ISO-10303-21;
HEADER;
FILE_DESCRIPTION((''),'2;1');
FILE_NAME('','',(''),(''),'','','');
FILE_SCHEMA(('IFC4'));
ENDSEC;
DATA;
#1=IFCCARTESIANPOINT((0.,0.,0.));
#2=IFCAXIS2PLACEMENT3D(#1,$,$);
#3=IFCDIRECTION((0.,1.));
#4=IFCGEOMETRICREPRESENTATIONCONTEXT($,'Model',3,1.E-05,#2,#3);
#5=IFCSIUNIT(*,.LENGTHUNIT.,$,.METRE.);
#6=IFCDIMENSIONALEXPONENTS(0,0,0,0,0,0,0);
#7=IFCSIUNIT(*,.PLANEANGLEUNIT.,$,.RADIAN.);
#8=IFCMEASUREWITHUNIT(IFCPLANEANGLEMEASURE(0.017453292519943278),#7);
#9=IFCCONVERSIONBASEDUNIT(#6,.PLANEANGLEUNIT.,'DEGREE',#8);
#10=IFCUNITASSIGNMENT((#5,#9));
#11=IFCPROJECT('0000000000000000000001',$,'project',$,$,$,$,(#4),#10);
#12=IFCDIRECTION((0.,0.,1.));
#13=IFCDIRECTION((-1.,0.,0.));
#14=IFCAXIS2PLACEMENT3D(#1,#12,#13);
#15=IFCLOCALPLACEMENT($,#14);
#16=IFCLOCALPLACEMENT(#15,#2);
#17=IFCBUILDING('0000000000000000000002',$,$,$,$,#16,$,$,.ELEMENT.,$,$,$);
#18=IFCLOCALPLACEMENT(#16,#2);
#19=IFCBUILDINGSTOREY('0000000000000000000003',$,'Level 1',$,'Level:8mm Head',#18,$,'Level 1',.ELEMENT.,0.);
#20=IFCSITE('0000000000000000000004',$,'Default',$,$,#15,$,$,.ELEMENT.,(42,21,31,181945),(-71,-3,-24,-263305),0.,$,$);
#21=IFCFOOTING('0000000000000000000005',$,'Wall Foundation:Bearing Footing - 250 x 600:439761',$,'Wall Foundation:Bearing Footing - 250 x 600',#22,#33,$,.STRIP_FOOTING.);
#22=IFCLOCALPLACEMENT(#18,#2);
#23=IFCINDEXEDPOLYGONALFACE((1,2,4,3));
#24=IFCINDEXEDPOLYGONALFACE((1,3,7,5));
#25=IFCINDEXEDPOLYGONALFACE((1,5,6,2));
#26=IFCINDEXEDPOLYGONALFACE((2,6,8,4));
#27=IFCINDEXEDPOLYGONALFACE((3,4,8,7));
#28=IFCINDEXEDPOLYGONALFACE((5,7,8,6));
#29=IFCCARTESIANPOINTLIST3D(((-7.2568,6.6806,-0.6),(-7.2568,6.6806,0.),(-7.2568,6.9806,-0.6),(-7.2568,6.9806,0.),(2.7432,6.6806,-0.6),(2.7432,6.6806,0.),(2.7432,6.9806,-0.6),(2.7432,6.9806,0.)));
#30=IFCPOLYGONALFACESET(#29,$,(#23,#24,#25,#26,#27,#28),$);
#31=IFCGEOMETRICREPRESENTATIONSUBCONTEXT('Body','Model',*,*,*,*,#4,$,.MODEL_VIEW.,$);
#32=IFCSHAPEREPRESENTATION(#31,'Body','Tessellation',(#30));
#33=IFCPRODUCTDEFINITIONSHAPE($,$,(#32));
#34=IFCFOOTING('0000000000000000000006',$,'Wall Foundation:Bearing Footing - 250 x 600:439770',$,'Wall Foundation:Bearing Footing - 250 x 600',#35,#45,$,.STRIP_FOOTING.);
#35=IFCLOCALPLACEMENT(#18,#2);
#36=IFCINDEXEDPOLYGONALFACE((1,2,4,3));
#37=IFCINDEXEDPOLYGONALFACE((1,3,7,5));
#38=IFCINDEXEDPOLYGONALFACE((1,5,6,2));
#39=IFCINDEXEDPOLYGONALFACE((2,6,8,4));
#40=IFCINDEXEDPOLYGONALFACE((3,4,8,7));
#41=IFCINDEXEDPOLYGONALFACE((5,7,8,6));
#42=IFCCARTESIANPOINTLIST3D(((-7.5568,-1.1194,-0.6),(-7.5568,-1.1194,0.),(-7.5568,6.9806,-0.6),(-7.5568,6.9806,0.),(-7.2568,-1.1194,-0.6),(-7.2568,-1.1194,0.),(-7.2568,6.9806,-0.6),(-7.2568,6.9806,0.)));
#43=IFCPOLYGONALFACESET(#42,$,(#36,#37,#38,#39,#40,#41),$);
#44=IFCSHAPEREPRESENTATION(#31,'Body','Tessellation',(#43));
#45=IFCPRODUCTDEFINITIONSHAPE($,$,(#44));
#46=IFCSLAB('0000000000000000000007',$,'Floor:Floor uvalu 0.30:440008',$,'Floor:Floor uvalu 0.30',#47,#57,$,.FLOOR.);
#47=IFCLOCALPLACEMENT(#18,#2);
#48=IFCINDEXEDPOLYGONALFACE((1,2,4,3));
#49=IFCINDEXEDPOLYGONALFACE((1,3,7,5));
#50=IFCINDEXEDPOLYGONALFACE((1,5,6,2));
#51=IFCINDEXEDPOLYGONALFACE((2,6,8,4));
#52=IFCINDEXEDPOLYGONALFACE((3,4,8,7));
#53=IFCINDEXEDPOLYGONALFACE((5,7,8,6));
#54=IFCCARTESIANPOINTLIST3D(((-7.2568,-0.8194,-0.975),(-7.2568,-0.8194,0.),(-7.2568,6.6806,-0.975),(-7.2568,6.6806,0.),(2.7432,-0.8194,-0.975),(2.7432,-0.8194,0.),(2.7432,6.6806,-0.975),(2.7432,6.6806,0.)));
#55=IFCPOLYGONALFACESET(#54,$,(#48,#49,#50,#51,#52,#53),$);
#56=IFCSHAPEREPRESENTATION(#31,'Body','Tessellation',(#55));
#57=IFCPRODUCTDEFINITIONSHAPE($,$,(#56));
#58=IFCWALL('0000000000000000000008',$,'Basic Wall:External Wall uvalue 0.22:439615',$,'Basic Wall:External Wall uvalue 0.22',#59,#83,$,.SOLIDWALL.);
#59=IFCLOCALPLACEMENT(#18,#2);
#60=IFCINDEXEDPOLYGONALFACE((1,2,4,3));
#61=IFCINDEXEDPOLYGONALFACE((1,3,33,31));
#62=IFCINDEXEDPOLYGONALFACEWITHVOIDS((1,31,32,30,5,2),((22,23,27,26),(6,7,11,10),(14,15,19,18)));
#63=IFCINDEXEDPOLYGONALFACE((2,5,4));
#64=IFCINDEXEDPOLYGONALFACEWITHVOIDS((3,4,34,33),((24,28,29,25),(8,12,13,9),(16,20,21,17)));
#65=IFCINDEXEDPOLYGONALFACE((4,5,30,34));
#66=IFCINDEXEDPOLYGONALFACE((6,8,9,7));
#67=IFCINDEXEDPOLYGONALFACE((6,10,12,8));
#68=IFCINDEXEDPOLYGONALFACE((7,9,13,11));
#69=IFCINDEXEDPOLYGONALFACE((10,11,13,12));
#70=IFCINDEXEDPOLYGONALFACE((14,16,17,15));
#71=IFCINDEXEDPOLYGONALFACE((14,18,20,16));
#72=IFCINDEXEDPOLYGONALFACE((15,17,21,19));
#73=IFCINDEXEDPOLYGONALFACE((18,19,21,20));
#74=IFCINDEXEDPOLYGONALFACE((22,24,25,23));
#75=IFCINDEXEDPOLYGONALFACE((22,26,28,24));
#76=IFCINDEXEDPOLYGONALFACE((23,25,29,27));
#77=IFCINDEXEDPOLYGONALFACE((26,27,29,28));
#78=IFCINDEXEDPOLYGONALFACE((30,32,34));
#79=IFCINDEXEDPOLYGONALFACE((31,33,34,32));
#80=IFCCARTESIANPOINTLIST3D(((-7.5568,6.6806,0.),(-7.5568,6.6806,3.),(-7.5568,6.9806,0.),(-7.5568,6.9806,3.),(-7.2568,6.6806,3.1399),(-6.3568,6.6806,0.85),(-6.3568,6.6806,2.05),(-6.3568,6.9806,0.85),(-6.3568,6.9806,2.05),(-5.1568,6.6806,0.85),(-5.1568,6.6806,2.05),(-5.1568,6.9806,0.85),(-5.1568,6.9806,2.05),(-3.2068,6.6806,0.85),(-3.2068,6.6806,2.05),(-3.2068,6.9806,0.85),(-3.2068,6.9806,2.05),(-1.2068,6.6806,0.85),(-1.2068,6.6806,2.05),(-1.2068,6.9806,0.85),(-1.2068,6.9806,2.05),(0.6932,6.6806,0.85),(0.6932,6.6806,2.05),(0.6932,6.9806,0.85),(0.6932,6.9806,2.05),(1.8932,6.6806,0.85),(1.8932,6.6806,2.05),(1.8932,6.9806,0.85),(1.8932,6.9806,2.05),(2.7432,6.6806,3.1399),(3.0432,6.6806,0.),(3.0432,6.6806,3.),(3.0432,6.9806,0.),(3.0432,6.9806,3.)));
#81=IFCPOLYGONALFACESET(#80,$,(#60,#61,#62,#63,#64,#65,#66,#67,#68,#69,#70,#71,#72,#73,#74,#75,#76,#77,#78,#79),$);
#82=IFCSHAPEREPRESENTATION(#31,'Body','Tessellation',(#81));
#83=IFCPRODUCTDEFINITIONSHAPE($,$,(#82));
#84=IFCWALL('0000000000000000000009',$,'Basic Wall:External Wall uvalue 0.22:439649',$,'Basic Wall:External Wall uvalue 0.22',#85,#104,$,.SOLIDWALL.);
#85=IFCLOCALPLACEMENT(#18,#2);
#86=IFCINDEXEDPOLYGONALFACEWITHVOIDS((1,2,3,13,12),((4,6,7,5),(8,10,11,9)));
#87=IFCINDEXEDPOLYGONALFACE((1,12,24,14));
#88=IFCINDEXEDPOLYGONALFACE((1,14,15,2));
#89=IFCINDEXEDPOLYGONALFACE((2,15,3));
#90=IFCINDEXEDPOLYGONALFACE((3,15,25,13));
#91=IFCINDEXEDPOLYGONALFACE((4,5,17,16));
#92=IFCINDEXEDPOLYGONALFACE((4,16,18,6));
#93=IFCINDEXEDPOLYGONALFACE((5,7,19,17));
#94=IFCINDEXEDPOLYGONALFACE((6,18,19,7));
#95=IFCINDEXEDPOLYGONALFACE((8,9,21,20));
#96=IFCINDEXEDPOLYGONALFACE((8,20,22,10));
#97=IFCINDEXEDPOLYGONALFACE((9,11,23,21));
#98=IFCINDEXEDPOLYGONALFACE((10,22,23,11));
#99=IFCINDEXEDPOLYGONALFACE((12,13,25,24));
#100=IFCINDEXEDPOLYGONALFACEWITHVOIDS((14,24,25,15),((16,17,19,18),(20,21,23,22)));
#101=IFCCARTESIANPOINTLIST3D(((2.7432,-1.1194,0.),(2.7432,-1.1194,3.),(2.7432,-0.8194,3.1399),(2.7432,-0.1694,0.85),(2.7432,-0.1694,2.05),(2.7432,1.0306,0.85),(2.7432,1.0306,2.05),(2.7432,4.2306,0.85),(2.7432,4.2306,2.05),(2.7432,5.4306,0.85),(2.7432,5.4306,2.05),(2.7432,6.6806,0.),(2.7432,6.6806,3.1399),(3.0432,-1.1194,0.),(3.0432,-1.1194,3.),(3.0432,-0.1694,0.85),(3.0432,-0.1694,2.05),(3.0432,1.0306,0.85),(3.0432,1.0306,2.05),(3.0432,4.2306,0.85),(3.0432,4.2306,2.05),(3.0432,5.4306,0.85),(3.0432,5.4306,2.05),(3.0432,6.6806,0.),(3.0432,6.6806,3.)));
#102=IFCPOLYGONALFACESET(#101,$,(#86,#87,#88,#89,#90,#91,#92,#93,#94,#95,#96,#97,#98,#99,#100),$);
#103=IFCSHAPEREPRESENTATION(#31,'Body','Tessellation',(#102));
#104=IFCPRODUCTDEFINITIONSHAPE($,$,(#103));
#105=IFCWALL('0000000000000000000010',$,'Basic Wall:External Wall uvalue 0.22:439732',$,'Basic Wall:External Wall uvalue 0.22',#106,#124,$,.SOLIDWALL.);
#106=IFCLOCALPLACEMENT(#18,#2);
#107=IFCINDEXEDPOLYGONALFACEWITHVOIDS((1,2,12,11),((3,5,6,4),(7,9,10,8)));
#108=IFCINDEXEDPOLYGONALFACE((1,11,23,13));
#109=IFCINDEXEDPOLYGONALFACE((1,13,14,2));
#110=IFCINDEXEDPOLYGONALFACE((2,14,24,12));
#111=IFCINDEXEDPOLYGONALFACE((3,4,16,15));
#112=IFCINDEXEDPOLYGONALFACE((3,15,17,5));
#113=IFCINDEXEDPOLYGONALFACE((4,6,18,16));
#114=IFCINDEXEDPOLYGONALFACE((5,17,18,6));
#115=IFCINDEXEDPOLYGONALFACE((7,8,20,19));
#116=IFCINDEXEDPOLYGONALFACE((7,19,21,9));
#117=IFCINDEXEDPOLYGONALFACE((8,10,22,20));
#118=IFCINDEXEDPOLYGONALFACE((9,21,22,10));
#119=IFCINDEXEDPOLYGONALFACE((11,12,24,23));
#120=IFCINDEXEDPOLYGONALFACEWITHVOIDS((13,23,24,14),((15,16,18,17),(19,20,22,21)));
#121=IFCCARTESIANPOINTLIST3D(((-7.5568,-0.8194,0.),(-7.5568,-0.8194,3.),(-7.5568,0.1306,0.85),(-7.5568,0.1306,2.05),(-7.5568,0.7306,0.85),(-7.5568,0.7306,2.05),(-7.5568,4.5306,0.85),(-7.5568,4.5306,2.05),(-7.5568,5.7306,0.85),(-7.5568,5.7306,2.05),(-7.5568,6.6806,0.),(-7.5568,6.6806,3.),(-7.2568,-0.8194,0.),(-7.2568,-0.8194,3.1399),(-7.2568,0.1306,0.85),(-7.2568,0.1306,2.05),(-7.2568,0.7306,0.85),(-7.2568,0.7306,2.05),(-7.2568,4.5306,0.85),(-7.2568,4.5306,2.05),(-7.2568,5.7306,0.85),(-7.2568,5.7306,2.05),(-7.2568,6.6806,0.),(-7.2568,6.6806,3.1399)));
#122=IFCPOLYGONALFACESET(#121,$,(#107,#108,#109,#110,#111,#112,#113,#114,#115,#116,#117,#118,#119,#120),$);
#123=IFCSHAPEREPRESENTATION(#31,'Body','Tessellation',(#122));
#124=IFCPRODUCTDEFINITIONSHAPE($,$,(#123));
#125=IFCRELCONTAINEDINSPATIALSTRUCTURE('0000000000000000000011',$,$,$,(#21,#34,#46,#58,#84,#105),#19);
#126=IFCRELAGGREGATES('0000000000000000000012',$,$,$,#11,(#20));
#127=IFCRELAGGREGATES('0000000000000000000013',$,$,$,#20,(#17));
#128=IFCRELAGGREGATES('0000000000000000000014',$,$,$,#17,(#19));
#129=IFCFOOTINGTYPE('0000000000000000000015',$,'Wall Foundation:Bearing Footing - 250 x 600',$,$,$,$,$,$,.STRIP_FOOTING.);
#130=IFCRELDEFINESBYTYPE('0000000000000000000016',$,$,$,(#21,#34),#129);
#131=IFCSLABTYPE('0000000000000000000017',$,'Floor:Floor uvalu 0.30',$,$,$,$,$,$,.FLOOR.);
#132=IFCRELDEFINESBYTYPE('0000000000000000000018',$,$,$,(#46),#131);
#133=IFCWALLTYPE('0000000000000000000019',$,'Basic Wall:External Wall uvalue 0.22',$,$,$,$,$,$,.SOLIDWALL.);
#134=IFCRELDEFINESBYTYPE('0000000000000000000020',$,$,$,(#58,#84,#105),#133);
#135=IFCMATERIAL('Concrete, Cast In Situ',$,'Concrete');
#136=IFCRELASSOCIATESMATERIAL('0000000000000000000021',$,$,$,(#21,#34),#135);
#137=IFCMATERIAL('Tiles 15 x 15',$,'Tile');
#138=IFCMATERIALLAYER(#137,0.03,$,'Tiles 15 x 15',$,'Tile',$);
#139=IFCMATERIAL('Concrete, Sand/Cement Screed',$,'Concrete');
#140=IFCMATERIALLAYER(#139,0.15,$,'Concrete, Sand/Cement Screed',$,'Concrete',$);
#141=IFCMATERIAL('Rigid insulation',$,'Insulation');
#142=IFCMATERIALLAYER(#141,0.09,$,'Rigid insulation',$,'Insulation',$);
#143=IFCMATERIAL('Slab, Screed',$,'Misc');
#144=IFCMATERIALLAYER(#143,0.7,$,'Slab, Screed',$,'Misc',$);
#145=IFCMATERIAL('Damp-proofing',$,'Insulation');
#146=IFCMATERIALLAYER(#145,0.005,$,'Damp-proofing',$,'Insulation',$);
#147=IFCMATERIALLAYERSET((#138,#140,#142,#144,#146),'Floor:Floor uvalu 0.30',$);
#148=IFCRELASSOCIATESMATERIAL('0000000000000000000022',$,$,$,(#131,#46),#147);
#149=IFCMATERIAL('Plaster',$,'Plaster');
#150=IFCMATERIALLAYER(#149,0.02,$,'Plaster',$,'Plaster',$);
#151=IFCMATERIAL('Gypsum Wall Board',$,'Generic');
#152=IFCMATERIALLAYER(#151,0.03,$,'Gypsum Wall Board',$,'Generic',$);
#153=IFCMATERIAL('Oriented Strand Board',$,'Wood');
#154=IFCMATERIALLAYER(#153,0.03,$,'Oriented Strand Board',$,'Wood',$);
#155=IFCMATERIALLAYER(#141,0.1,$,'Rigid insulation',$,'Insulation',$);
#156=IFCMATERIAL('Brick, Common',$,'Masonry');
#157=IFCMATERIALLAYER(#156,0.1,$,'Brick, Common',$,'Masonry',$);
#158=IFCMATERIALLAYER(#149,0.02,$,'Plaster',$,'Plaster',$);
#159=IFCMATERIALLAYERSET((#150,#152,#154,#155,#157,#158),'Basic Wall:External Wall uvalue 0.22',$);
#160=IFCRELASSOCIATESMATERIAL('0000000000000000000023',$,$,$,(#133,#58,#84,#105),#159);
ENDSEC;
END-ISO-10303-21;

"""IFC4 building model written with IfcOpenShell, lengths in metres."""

from ifc_helpers import new_model, entity, si_unit, converted_unit, direction, frame, frame_2d, origin, origin_2d_with_axis, place, context, subcontext, project, spatial, polyline, rectangle, extrude, clip, bounded_halfspace, material, layer, layer_set, layer_usage, type_object, element, save


model = new_model("IFC4")

# Units and contexts
model_context = context("Model", 3, precision=1e-05, world=origin(), true_north=direction((0.0, 1.0)))
body_context = subcontext(model_context, "Body", "Model", "MODEL_VIEW")
ifc_project = project(units=[si_unit("LENGTHUNIT", "METRE"), converted_unit("PLANEANGLEUNIT", "DEGREE", entity("IfcPlaneAngleMeasure", 0.017453292519943278), si_unit("PLANEANGLEUNIT", "RADIAN"), dimensions=[0, 0, 0, 0, 0, 0, 0])], contexts=[model_context])

# Site, building, storey
site_placement = place(None, frame((0.0, 0.0, 0.0), z_axis=(0.0, 0.0, 1.0), x_axis=(-1.0, 0.0, 0.0)))
site = spatial("IfcSite", under=ifc_project, at=site_placement, Name="Default", CompositionType="ELEMENT", RefLatitude=(42, 21, 31, 181945), RefLongitude=(-71, -3, -24, -263305), RefElevation=0.0)
building_placement = place(site_placement, origin())
building = spatial("IfcBuilding", under=site, at=building_placement, CompositionType="ELEMENT")
storey_placement = place(building_placement, origin())
storey = spatial("IfcBuildingStorey", under=building, at=storey_placement, Name="Level 1", ObjectType="Level:8mm Head", LongName="Level 1", CompositionType="ELEMENT", Elevation=0.0)

# Footings
ifc_material_1 = material(Name="Concrete, Cast In Situ", Category="Concrete")
footing_type = type_object("IfcFootingType", Name="Wall Foundation:Bearing Footing - 250 x 600", PredefinedType="STRIP_FOOTING")
footing_1_placement = place(storey_placement, frame((-7.2568, 6.6806, -0.6)))
element("IfcFooting", 1, at=footing_1_placement, inside=storey, type_object=footing_type, material=ifc_material_1, Name="Wall Foundation:Bearing Footing - 250 x 600:439761", ObjectType="Wall Foundation:Bearing Footing - 250 x 600", PredefinedType="STRIP_FOOTING", context=body_context, shape_type="SweptSolid", body=[
    extrude(rectangle(XDim=10.0, YDim=0.3, at=frame_2d((0.0, 0.0), x_axis=(1.0, 0.0))), frame((5.0, 0.15, 0.0)), (0.0, 0.0, 1.0), 0.6),
])
footing_2_placement = place(storey_placement, frame((-7.5568, -1.1194, -0.6)))
element("IfcFooting", 2, at=footing_2_placement, inside=storey, type_object=footing_type, material=ifc_material_1, Name="Wall Foundation:Bearing Footing - 250 x 600:439770", ObjectType="Wall Foundation:Bearing Footing - 250 x 600", PredefinedType="STRIP_FOOTING", context=body_context, shape_type="SweptSolid", body=[
    extrude(rectangle(XDim=8.1, YDim=0.3, at=frame_2d((0.0, 0.05), x_axis=(1.0, 0.0))), frame((0.2, 4.05, 0.0), z_axis=(0.0, 0.0, 1.0), x_axis=(0.0, 1.0, 0.0)), (0.0, 0.0, 1.0), 0.6),
])

# Slab
ifc_material_2 = material(Name="Tiles 15 x 15", Category="Tile")
ifc_layer_1 = layer(ifc_material_2, 0.03, Name="Tiles 15 x 15", Category="Tile")
ifc_material_3 = material(Name="Concrete, Sand/Cement Screed", Category="Concrete")
ifc_layer_2 = layer(ifc_material_3, 0.15, Name="Concrete, Sand/Cement Screed", Category="Concrete")
ifc_material_4 = material(Name="Rigid insulation", Category="Insulation")
ifc_layer_3 = layer(ifc_material_4, 0.09, Name="Rigid insulation", Category="Insulation")
ifc_material_5 = material(Name="Slab, Screed", Category="Misc")
ifc_layer_4 = layer(ifc_material_5, 0.7, Name="Slab, Screed", Category="Misc")
ifc_material_6 = material(Name="Damp-proofing", Category="Insulation")
ifc_layer_5 = layer(ifc_material_6, 0.005, Name="Damp-proofing", Category="Insulation")
ifc_layer_set_1 = layer_set([ifc_layer_1, ifc_layer_2, ifc_layer_3, ifc_layer_4, ifc_layer_5], Name="Floor:Floor uvalu 0.30")
ifc_layer_usage_1 = layer_usage(ifc_layer_set_1, "AXIS3", "POSITIVE", 0.0)
slab_type = type_object("IfcSlabType", Name="Floor:Floor uvalu 0.30", PredefinedType="FLOOR", material=ifc_layer_set_1)
slab_placement = place(storey_placement, origin())
element("IfcSlab", 3, at=slab_placement, inside=storey, type_object=slab_type, material=ifc_layer_usage_1, Name="Floor:Floor uvalu 0.30:440008", ObjectType="Floor:Floor uvalu 0.30", PredefinedType="FLOOR", context=body_context, shape_type="SweptSolid", body=[
    extrude(rectangle(XDim=7.5, YDim=10.0, at=origin_2d_with_axis()), frame((-2.2568, 2.9306, 0.0), z_axis=(0.0, 0.0, -1.0), x_axis=(0.0, 1.0, 0.0)), (0.0, 0.0, 1.0), 0.975),
])

# Walls, openings
ifc_material_7 = material(Name="Plaster", Category="Plaster")
ifc_layer_6 = layer(ifc_material_7, 0.02, Name="Plaster", Category="Plaster")
ifc_material_8 = material(Name="Gypsum Wall Board", Category="Generic")
ifc_layer_7 = layer(ifc_material_8, 0.03, Name="Gypsum Wall Board", Category="Generic")
ifc_material_9 = material(Name="Oriented Strand Board", Category="Wood")
ifc_layer_8 = layer(ifc_material_9, 0.03, Name="Oriented Strand Board", Category="Wood")
ifc_layer_9 = layer(ifc_material_4, 0.1, Name="Rigid insulation", Category="Insulation")
ifc_material_10 = material(Name="Brick, Common", Category="Masonry")
ifc_layer_10 = layer(ifc_material_10, 0.1, Name="Brick, Common", Category="Masonry")
ifc_layer_11 = layer(ifc_material_7, 0.02, Name="Plaster", Category="Plaster")
ifc_layer_set_2 = layer_set([ifc_layer_6, ifc_layer_7, ifc_layer_8, ifc_layer_9, ifc_layer_10, ifc_layer_11], Name="Basic Wall:External Wall uvalue 0.22")
ifc_layer_usage_2 = layer_usage(ifc_layer_set_2, "AXIS2", "NEGATIVE", 0.15)
wall_type_1 = type_object("IfcWallType", Name="Basic Wall:External Wall uvalue 0.22", PredefinedType="SOLIDWALL", material=ifc_layer_set_2)
wall_1_placement = place(storey_placement, frame((-7.5568, 6.8306, 0.0)))
wall_1 = element("IfcWall", 4, at=wall_1_placement, inside=storey, type_object=wall_type_1, material=ifc_layer_usage_2, Name="Basic Wall:External Wall uvalue 0.22:439615", ObjectType="Basic Wall:External Wall uvalue 0.22", PredefinedType="SOLIDWALL", context=body_context, shape_type="Clipping", body=[
    clip(clip(clip(extrude(rectangle(XDim=10.6, YDim=0.3, at=frame_2d((5.3, 0.0), x_axis=(-1.0, 0.0))), origin(), (0.0, 0.0, 1.0), 3.1399), bounded_halfspace(frame((0.3, -0.15, 3.1399), z_axis=(0.0, 0.422618, 0.906308), x_axis=(-1.0, 0.0, 0.0)), False, frame((0.3, -0.15, 3.1399)), polyline([(0.0, 0.0), (10.0, 0.0), (10.3, 0.3), (-0.3, 0.3), (0.0, 0.0)]))), bounded_halfspace(frame((0.0, -0.15, 3.0), z_axis=(-0.422618, 0.0, 0.906308), x_axis=(0.0, -1.0, 0.0)), False, frame((0.0, -0.15, 3.0)), polyline([(0.0, 0.0), (0.3, 0.0), (0.0, 0.3), (0.0, 0.0)]))), bounded_halfspace(frame((10.3, -0.15, 3.1399), z_axis=(0.422618, 0.0, 0.906308), x_axis=(0.0, 1.0, 0.0)), False, frame((10.3, -0.15, 3.1399)), polyline([(0.0, 0.0), (0.3, 0.0), (0.3, 0.3), (0.0, 0.0)]))),
])
opening_1_placement = place(wall_1_placement, frame((1.2, -0.15, 0.85)))
element("IfcOpeningElement", 5, at=opening_1_placement, cuts=wall_1, PredefinedType="OPENING", context=body_context, shape_type="SweptSolid", body=[
    extrude(rectangle(XDim=1.2, YDim=1.2, at=frame_2d((0.6, 0.6), x_axis=(1.0, 0.0))), frame((0.0, 0.0, 0.0), z_axis=(0.0, 1.0, 0.0), x_axis=(0.0, 0.0, 1.0)), (0.0, 0.0, 1.0), 0.3),
])
opening_2_placement = place(wall_1_placement, frame((8.25, -0.15, 0.85)))
element("IfcOpeningElement", 6, at=opening_2_placement, cuts=wall_1, PredefinedType="OPENING", context=body_context, shape_type="SweptSolid", body=[
    extrude(rectangle(XDim=1.2, YDim=1.2, at=frame_2d((0.6, 0.6), x_axis=(1.0, 0.0))), frame((0.0, 0.0, 0.0), z_axis=(0.0, 1.0, 0.0), x_axis=(0.0, 0.0, 1.0)), (0.0, 0.0, 1.0), 0.3),
])
opening_3_placement = place(wall_1_placement, frame((4.35, -0.15, 0.85)))
element("IfcOpeningElement", 7, at=opening_3_placement, cuts=wall_1, PredefinedType="OPENING", context=body_context, shape_type="SweptSolid", body=[
    extrude(rectangle(XDim=1.2, YDim=2.0, at=frame_2d((0.6, 1.0), x_axis=(1.0, 0.0))), frame((0.0, 0.0, 0.0), z_axis=(0.0, 1.0, 0.0), x_axis=(0.0, 0.0, 1.0)), (0.0, 0.0, 1.0), 0.3),
])
wall_2_placement = place(storey_placement, frame((2.8932, 6.6806, 0.0), z_axis=(0.0, 0.0, 1.0), x_axis=(0.0, -1.0, 0.0)))
wall_2 = element("IfcWall", 8, at=wall_2_placement, inside=storey, type_object=wall_type_1, material=ifc_layer_usage_2, Name="Basic Wall:External Wall uvalue 0.22:439649", ObjectType="Basic Wall:External Wall uvalue 0.22", PredefinedType="SOLIDWALL", context=body_context, shape_type="Clipping", body=[
    clip(clip(extrude(rectangle(XDim=7.8, YDim=0.3, at=frame_2d((3.9, 0.0), x_axis=(-1.0, 0.0))), origin(), (0.0, 0.0, 1.0), 3.1399), bounded_halfspace(frame((7.5, -0.15, 3.1399), z_axis=(0.422618, 0.0, 0.906308), x_axis=(0.0, 1.0, 0.0)), False, frame((7.5, -0.15, 3.1399)), polyline([(0.0, 0.0), (0.3, 0.0), (0.3, 0.3), (0.0, 0.0)]))), bounded_halfspace(frame((0.0, -0.15, 3.1399), z_axis=(0.0, 0.422618, 0.906308), x_axis=(-1.0, 0.0, 0.0)), False, frame((0.0, -0.15, 3.1399)), polyline([(0.0, 0.0), (7.5, 0.0), (7.8, 0.3), (0.0, 0.3), (0.0, 0.0)]))),
])
opening_4_placement = place(wall_2_placement, frame((1.25, -0.15, 0.85)))
element("IfcOpeningElement", 9, at=opening_4_placement, cuts=wall_2, PredefinedType="OPENING", context=body_context, shape_type="SweptSolid", body=[
    extrude(rectangle(XDim=1.2, YDim=1.2, at=frame_2d((0.6, 0.6), x_axis=(1.0, 0.0))), frame((0.0, 0.0, 0.0), z_axis=(0.0, 1.0, 0.0), x_axis=(0.0, 0.0, 1.0)), (0.0, 0.0, 1.0), 0.3),
])
opening_5_placement = place(wall_2_placement, frame((6.85, 0.15, 0.85)))
element("IfcOpeningElement", 10, at=opening_5_placement, cuts=wall_2, PredefinedType="OPENING", context=body_context, shape_type="SweptSolid", body=[
    extrude(rectangle(XDim=1.2, YDim=1.2, at=frame_2d((0.6, 0.6), x_axis=(1.0, 0.0))), frame((0.0, 0.0, 0.0), z_axis=(0.0, -1.0, 0.0), x_axis=(0.0, 0.0, 1.0)), (0.0, 0.0, 1.0), 0.3),
])
wall_3_placement = place(storey_placement, frame((-7.4068, -0.8194, 0.0), z_axis=(0.0, 0.0, 1.0), x_axis=(0.0, 1.0, 0.0)))
wall_3 = element("IfcWall", 11, at=wall_3_placement, inside=storey, type_object=wall_type_1, material=ifc_layer_usage_2, Name="Basic Wall:External Wall uvalue 0.22:439732", ObjectType="Basic Wall:External Wall uvalue 0.22", PredefinedType="SOLIDWALL", context=body_context, shape_type="Clipping", body=[
    clip(extrude(rectangle(XDim=7.5, YDim=0.3, at=frame_2d((3.75, 0.0), x_axis=(-1.0, 0.0))), origin(), (0.0, 0.0, 1.0), 3.1399), bounded_halfspace(frame((0.0, -0.15, 3.1399), z_axis=(0.0, 0.422618, 0.906308), x_axis=(-1.0, 0.0, 0.0)), False, frame((0.0, -0.15, 3.1399)), polyline([(0.0, 0.0), (7.5, 0.0), (7.5, 0.3), (0.0, 0.3), (0.0, 0.0)]))),
])
opening_6_placement = place(wall_3_placement, frame((5.35, -0.15, 0.85)))
element("IfcOpeningElement", 12, at=opening_6_placement, cuts=wall_3, PredefinedType="OPENING", context=body_context, shape_type="SweptSolid", body=[
    extrude(rectangle(XDim=1.2, YDim=1.2, at=frame_2d((0.6, 0.6), x_axis=(1.0, 0.0))), frame((0.0, 0.0, 0.0), z_axis=(0.0, 1.0, 0.0), x_axis=(0.0, 0.0, 1.0)), (0.0, 0.0, 1.0), 0.3),
])
opening_7_placement = place(wall_3_placement, frame((0.95, -0.15, 0.85)))
element("IfcOpeningElement", 13, at=opening_7_placement, cuts=wall_3, PredefinedType="OPENING", context=body_context, shape_type="SweptSolid", body=[
    extrude(rectangle(XDim=1.2, YDim=0.6, at=frame_2d((0.6, 0.3), x_axis=(1.0, 0.0))), frame((0.0, 0.0, 0.0), z_axis=(0.0, 1.0, 0.0), x_axis=(0.0, 0.0, 1.0)), (0.0, 0.0, 1.0), 0.3),
])

save(model, "model.ifc")
